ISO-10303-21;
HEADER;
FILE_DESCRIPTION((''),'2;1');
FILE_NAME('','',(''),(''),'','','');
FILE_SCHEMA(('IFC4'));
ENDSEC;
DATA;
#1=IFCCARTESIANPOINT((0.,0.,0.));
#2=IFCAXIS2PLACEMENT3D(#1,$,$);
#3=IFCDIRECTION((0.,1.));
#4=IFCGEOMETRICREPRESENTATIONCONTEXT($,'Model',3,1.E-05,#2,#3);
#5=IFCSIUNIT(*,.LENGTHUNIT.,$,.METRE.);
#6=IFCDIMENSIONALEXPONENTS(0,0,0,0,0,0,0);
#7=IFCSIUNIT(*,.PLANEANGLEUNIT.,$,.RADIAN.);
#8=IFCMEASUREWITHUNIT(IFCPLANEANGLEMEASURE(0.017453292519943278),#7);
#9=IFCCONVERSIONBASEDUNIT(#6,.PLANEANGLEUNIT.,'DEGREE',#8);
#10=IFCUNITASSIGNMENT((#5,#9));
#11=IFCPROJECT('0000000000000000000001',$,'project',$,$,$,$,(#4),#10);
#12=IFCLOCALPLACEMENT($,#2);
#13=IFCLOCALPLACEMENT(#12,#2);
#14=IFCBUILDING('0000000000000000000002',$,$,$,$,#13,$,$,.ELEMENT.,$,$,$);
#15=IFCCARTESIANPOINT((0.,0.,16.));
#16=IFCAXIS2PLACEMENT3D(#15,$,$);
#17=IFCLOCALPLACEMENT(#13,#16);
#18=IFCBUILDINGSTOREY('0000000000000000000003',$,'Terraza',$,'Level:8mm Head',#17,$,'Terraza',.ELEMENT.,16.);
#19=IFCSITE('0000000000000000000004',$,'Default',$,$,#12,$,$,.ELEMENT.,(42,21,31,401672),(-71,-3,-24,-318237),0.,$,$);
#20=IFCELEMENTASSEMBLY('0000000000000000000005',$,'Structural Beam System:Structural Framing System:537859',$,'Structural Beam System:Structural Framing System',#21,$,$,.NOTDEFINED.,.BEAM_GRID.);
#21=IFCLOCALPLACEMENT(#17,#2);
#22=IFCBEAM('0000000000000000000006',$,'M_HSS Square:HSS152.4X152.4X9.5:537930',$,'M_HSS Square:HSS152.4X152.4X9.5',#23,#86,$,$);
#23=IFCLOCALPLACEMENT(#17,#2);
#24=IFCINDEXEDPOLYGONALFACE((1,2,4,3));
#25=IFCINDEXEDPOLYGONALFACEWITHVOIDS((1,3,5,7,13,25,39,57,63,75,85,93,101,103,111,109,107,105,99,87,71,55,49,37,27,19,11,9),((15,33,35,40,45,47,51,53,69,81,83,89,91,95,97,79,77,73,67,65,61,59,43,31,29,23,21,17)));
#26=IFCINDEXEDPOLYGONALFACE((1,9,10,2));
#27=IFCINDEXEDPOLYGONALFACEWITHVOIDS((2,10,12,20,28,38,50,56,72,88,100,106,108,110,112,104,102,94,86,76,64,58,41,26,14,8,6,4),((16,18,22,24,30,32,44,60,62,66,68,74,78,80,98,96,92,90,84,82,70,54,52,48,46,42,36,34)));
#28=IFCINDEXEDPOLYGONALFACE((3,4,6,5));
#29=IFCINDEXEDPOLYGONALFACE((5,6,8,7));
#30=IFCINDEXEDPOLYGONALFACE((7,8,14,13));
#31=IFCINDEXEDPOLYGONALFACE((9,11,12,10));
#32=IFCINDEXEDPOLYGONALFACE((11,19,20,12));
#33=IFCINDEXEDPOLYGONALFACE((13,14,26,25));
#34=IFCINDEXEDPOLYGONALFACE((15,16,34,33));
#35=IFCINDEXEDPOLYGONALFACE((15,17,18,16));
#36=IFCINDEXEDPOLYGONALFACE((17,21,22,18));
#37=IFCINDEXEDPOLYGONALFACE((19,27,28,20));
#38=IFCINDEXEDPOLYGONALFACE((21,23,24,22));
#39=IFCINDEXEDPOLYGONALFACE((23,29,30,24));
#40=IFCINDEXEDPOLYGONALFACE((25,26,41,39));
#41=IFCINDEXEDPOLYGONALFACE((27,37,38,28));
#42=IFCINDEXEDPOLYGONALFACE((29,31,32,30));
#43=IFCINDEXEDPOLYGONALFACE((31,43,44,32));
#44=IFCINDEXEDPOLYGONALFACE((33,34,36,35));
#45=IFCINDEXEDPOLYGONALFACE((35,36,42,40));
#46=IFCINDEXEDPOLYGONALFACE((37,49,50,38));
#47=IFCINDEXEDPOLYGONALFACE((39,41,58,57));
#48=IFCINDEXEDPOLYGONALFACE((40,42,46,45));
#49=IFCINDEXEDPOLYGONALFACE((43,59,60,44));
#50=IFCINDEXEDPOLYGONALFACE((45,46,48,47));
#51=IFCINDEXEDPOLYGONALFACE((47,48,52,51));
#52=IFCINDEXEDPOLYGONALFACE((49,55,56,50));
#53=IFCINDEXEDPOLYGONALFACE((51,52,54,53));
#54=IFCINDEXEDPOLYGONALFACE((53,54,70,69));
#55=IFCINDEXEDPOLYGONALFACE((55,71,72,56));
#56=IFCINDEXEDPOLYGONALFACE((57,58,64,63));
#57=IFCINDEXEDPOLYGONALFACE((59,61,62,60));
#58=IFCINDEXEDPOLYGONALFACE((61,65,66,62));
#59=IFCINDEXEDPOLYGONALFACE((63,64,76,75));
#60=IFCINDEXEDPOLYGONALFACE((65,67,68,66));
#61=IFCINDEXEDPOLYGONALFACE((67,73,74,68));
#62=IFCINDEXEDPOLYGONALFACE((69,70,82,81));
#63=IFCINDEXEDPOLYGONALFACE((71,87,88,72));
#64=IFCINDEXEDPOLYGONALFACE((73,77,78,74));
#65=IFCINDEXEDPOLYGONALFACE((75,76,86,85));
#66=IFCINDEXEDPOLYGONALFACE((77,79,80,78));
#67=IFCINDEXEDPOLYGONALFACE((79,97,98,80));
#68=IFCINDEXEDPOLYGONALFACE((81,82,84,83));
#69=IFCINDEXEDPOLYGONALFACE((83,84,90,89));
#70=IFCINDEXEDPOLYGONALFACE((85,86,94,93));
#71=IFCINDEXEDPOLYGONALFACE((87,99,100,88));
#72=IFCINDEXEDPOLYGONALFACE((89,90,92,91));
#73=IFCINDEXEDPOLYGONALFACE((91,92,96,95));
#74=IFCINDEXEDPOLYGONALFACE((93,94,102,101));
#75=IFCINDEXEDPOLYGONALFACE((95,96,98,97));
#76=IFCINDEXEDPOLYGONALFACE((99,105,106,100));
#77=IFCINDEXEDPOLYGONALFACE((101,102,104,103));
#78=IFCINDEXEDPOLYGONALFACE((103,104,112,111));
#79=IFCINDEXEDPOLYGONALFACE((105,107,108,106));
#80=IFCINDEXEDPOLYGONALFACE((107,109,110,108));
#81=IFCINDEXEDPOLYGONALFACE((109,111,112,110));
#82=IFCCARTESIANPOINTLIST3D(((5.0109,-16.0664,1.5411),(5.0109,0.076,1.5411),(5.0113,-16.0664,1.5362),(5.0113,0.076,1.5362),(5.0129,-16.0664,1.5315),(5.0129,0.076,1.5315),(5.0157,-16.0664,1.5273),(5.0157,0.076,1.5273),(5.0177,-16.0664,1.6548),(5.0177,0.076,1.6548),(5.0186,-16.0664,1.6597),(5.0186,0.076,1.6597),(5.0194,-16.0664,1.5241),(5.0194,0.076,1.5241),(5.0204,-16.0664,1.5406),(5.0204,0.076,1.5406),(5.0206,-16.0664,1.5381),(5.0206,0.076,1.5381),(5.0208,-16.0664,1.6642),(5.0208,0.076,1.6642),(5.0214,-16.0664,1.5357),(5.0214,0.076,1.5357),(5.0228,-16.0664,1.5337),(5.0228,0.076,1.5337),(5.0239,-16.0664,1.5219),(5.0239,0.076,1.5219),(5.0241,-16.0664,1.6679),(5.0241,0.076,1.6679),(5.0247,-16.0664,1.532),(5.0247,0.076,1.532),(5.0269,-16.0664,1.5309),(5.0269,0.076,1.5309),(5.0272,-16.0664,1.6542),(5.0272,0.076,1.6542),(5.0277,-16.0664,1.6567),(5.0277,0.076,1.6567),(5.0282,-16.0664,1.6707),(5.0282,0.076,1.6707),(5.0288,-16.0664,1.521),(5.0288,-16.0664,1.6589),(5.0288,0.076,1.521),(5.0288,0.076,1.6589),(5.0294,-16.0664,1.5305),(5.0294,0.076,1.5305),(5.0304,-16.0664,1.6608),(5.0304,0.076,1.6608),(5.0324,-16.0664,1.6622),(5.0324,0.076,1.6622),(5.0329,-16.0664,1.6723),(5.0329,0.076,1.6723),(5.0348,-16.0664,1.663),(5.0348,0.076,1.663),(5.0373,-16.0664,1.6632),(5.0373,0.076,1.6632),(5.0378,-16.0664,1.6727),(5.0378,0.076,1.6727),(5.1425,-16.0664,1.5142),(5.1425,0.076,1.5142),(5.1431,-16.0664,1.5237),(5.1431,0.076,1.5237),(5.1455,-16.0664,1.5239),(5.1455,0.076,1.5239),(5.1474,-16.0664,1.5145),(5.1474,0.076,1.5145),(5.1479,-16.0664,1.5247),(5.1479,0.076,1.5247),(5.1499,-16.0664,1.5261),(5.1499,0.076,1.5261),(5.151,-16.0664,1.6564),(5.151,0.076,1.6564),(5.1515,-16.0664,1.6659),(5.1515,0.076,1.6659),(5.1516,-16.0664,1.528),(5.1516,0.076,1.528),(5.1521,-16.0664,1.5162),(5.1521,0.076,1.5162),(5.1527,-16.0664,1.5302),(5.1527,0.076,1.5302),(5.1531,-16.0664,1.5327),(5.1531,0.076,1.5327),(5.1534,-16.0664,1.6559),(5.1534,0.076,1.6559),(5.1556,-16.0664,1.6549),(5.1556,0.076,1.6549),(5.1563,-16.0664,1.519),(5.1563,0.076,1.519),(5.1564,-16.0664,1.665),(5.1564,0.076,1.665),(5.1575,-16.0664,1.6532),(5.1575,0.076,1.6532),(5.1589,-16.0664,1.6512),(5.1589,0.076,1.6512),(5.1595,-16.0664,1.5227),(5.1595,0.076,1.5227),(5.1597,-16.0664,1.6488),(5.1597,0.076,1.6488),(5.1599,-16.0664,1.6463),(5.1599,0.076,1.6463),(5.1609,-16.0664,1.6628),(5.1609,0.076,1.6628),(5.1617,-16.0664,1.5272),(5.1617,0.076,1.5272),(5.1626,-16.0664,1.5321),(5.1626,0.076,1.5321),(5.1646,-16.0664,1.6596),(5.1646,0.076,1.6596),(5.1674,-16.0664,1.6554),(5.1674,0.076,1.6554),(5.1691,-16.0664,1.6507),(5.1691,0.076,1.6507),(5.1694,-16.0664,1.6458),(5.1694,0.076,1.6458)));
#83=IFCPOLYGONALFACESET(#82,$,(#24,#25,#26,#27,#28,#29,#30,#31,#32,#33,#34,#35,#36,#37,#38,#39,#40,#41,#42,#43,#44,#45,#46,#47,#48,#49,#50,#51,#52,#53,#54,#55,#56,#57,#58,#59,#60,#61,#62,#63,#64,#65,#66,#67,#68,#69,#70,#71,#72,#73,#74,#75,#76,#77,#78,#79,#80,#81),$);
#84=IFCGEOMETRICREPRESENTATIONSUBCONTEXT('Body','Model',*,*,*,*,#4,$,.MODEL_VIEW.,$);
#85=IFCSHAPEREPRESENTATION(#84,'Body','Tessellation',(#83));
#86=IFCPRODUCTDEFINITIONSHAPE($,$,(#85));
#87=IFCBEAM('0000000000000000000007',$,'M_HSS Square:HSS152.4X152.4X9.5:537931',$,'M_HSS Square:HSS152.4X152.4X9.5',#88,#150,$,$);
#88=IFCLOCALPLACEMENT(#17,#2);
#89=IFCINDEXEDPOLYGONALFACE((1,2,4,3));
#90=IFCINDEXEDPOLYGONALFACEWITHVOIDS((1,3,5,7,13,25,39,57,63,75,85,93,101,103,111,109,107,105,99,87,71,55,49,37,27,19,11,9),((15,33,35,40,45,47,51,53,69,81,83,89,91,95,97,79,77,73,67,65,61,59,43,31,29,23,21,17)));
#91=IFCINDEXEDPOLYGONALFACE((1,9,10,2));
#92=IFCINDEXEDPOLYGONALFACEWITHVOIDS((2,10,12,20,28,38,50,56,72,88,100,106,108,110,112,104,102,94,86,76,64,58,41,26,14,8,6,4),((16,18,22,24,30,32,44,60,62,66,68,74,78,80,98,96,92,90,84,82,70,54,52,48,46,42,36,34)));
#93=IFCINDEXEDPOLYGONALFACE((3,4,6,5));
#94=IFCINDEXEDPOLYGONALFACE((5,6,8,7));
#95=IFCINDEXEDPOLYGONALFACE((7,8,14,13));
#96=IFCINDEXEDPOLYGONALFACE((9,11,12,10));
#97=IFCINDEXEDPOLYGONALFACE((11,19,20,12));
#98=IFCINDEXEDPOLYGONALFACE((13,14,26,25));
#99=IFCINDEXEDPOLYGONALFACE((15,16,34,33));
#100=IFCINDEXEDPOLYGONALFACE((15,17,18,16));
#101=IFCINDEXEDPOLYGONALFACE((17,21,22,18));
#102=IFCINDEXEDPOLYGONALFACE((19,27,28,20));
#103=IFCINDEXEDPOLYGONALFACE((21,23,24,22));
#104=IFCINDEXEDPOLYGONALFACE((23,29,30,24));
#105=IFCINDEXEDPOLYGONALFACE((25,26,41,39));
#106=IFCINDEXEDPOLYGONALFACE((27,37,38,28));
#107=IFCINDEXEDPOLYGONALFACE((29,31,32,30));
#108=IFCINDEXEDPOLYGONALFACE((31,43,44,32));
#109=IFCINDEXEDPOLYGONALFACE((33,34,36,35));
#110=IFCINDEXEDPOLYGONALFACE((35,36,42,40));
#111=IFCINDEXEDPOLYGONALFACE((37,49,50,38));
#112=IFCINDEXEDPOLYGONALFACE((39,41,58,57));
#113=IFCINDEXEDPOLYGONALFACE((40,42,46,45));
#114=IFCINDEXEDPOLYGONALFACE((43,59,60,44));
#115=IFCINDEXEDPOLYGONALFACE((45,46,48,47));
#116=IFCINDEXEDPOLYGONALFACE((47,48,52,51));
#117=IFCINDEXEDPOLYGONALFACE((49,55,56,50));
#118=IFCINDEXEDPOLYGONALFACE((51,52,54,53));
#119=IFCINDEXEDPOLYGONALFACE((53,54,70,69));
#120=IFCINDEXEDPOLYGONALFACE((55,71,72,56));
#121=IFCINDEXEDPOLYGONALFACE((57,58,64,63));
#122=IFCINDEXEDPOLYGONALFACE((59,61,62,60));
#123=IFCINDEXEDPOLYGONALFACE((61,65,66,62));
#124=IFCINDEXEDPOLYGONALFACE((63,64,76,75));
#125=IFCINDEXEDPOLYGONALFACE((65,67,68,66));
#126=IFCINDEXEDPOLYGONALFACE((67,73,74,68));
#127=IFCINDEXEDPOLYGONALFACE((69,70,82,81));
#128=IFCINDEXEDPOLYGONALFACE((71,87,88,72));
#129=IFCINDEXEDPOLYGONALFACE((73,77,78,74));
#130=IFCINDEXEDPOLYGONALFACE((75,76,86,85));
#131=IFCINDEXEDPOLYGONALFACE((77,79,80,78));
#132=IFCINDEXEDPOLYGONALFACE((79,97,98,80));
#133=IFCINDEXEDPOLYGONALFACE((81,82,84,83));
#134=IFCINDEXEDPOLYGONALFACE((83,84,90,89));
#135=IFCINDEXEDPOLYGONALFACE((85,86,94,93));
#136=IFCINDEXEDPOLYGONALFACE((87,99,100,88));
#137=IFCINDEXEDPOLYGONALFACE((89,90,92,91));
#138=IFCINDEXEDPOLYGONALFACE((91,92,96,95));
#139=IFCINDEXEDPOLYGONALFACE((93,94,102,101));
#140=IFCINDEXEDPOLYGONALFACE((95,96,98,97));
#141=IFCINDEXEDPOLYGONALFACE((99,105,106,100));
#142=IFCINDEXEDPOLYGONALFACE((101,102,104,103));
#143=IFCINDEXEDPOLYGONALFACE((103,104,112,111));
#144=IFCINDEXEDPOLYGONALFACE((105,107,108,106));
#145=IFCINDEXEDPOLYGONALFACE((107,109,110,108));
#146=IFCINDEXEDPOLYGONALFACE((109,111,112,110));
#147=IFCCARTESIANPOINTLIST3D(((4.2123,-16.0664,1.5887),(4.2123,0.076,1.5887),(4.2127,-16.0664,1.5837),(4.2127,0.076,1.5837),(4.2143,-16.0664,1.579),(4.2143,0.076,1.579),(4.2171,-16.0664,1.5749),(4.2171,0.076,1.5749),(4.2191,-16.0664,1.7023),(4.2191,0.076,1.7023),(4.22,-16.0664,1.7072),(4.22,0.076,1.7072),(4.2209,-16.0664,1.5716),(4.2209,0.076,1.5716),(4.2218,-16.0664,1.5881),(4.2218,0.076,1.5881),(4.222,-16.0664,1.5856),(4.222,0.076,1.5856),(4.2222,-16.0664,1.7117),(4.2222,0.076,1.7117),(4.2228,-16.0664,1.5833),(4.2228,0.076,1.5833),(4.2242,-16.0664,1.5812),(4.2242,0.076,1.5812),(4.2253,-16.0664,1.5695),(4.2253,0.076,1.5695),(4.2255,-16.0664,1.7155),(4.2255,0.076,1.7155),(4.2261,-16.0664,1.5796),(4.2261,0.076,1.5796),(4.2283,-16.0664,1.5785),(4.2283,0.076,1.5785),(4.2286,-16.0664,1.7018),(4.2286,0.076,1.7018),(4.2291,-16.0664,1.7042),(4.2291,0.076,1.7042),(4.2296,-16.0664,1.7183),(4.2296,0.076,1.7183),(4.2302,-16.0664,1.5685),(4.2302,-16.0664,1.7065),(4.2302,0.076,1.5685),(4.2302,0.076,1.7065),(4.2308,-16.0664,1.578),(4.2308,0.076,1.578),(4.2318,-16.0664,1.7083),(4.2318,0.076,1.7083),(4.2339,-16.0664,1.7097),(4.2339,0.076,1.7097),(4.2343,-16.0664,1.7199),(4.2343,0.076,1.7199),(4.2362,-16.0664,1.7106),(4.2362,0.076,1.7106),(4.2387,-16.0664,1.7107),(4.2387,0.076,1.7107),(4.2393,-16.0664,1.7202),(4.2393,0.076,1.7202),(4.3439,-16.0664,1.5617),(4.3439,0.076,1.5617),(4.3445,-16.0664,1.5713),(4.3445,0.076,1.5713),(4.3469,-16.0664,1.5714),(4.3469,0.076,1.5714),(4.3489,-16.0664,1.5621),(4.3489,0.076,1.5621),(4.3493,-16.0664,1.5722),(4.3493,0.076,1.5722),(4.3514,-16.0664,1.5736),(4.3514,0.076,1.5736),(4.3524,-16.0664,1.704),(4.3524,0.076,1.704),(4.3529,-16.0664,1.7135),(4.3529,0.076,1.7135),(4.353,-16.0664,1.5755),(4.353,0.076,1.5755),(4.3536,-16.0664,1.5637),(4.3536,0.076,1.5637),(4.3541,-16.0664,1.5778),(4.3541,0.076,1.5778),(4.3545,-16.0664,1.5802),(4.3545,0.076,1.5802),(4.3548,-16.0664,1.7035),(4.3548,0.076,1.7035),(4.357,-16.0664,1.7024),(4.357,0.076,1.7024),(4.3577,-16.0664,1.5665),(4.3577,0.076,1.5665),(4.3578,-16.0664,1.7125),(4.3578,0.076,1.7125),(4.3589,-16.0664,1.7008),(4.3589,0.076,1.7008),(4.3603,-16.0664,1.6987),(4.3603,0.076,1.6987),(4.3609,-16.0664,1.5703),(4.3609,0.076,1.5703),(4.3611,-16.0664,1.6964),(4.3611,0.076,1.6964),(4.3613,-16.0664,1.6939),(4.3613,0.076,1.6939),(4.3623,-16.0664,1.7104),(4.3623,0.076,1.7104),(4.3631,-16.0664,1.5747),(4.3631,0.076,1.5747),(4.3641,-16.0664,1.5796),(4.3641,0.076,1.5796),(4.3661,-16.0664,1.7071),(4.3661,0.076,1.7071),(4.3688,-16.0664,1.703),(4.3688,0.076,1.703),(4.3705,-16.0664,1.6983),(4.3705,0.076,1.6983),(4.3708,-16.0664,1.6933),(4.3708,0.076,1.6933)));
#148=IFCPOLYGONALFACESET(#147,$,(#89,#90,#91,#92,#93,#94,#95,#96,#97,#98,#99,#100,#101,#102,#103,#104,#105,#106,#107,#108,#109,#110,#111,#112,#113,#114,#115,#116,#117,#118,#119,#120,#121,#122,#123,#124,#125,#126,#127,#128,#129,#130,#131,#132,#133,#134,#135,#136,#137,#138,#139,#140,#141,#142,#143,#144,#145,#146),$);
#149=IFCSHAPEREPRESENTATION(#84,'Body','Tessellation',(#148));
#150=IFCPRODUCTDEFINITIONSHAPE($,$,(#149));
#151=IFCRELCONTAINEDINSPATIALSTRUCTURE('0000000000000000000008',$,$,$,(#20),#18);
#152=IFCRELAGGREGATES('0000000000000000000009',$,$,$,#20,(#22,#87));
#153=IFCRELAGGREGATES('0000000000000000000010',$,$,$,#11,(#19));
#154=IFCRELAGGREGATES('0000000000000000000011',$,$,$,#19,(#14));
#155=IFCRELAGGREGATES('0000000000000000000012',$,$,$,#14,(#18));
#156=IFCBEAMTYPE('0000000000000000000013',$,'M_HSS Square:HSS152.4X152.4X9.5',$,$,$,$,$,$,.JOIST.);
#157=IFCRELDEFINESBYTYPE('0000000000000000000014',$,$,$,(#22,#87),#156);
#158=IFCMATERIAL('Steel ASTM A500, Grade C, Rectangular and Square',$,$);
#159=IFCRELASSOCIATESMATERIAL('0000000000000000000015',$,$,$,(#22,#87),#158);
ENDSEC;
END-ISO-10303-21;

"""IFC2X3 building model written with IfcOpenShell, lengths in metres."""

from ifc_helpers import new_model, entity, si_unit, converted_unit, direction, frame, frame_2d, origin, place, context, subcontext, project, spatial, polyline, circle_curve, parameter, trimmed, segment, composite_curve, outline, extrude, material, type_object, element, aggregate, save


model = new_model("IFC2X3")

# Units and contexts
model_context = context("Model", 3, precision=1e-05, world=origin(), true_north=direction((0.0, 1.0)))
body_context = subcontext(model_context, "Body", "Model", "MODEL_VIEW")
ifc_project = project(units=[si_unit("LENGTHUNIT", "METRE"), converted_unit("PLANEANGLEUNIT", "DEGREE", entity("IfcPlaneAngleMeasure", 0.017453292519943278), si_unit("PLANEANGLEUNIT", "RADIAN"), dimensions=[0, 0, 0, 0, 0, 0, 0])], contexts=[model_context])

# Site, building, storey
site_placement = place(None, origin())
site = spatial("IfcSite", under=ifc_project, at=site_placement, Name="Default", CompositionType="ELEMENT", RefLatitude=(42, 21, 31, 401672), RefLongitude=(-71, -3, -24, -318237), RefElevation=0.0)
building_placement = place(site_placement, origin())
building = spatial("IfcBuilding", under=site, at=building_placement, CompositionType="ELEMENT")
storey_placement = place(building_placement, frame((0.0, 0.0, 16.0)))
storey = spatial("IfcBuildingStorey", under=building, at=storey_placement, Name="Terraza", ObjectType="Level:8mm Head", LongName="Terraza", CompositionType="ELEMENT", Elevation=16.0)

# Element assembly, beams
assembly_1_placement = place(storey_placement, origin())
assembly_1 = element("IfcElementAssembly", 1, at=assembly_1_placement, inside=storey, Name="Structural Beam System:Structural Framing System:537859", ObjectType="Structural Beam System:Structural Framing System", AssemblyPlace="NOTDEFINED", PredefinedType="BEAM_GRID")
ifc_material_1 = material(Name="Steel ASTM A500, Grade C, Rectangular and Square")
beam_type = type_object("IfcBeamType", Name="M_HSS Square:HSS152.4X152.4X9.5", PredefinedType="JOIST")
beam_1_placement = place(assembly_1_placement, frame((5.0856, 0.076, 1.5176), z_axis=(0.0, 0.0, 1.0), x_axis=(0.0, -1.0, 0.0)))
beam_1 = element("IfcBeam", 2, at=beam_1_placement, type_object=beam_type, material=ifc_material_1, Name="M_HSS Square:HSS152.4X152.4X9.5:537930", ObjectType="M_HSS Square:HSS152.4X152.4X9.5", context=body_context, shape_type="SweptSolid", body=[
    extrude(outline(composite_curve([segment(polyline([(-0.0569, -0.076), (0.0569, -0.076)]), True, "CONTINUOUS"), segment(trimmed(circle_curve(frame_2d((0.0569, -0.0569), x_axis=(0.0, 1.0)), 0.0191), [parameter(180.0)], [parameter(270.0)], True, "PARAMETER"), True, "CONTINUOUS"), segment(polyline([(0.076, -0.0569), (0.076, 0.0569)]), True, "CONTINUOUS"), segment(trimmed(circle_curve(frame_2d((0.0569, 0.0569), x_axis=(0.0, 1.0)), 0.0191), [parameter(270.0)], [parameter(0.0)], True, "PARAMETER"), True, "CONTINUOUS"), segment(polyline([(0.0569, 0.076), (-0.0569, 0.076)]), True, "CONTINUOUS"), segment(trimmed(circle_curve(frame_2d((-0.0569, 0.0569), x_axis=(0.0, 1.0)), 0.0191), [parameter(0.0)], [parameter(90.0)], True, "PARAMETER"), True, "CONTINUOUS"), segment(polyline([(-0.076, 0.0569), (-0.076, -0.0569)]), True, "CONTINUOUS"), segment(trimmed(circle_curve(frame_2d((-0.0569, -0.0569), x_axis=(0.0, 1.0)), 0.0191), [parameter(90.0)], [parameter(180.0)], True, "PARAMETER"), True, "CONTINUOUS")], self_intersect=False), holes=[composite_curve([segment(trimmed(circle_curve(frame_2d((-0.0569, 0.0569), x_axis=(0.0, 1.0)), 0.0095), [parameter(360.0)], [parameter(90.0)], True, "PARAMETER"), False, "CONTINUOUS"), segment(polyline([(-0.0569, 0.0665), (0.0569, 0.0665)]), True, "CONTINUOUS"), segment(trimmed(circle_curve(frame_2d((0.0569, 0.0569), x_axis=(0.0, 1.0)), 0.0095), [parameter(270.0)], [parameter(360.0)], True, "PARAMETER"), False, "CONTINUOUS"), segment(polyline([(0.0665, 0.0569), (0.0665, -0.0569)]), True, "CONTINUOUS"), segment(trimmed(circle_curve(frame_2d((0.0569, -0.0569), x_axis=(0.0, 1.0)), 0.0095), [parameter(180.0)], [parameter(270.0)], True, "PARAMETER"), False, "CONTINUOUS"), segment(polyline([(0.0569, -0.0665), (-0.0569, -0.0665)]), True, "CONTINUOUS"), segment(trimmed(circle_curve(frame_2d((-0.0569, -0.0569), x_axis=(0.0, 1.0)), 0.0095), [parameter(90.0)], [parameter(180.0)], True, "PARAMETER"), False, "CONTINUOUS"), segment(polyline([(-0.0665, -0.0569), (-0.0665, 0.0569)]), True, "CONTINUOUS")], self_intersect=False)]), frame((0.0, 0.0045, 0.0759), z_axis=(1.0, 0.0, 0.0), x_axis=(0.0, -0.059434, -0.998232)), (0.0, 0.0, 1.0), 16.1424),
])
beam_2_placement = place(assembly_1_placement, frame((4.2871, 0.076, 1.5651), z_axis=(0.0, 0.0, 1.0), x_axis=(0.0, -1.0, 0.0)))
beam_2 = element("IfcBeam", 3, at=beam_2_placement, type_object=beam_type, material=ifc_material_1, Name="M_HSS Square:HSS152.4X152.4X9.5:537931", ObjectType="M_HSS Square:HSS152.4X152.4X9.5", context=body_context, shape_type="SweptSolid", body=[
    extrude(outline(composite_curve([segment(polyline([(-0.0569, -0.076), (0.0569, -0.076)]), True, "CONTINUOUS"), segment(trimmed(circle_curve(frame_2d((0.0569, -0.0569), x_axis=(0.0, 1.0)), 0.0191), [parameter(180.0)], [parameter(270.0)], True, "PARAMETER"), True, "CONTINUOUS"), segment(polyline([(0.076, -0.0569), (0.076, 0.0569)]), True, "CONTINUOUS"), segment(trimmed(circle_curve(frame_2d((0.0569, 0.0569), x_axis=(0.0, 1.0)), 0.0191), [parameter(270.0)], [parameter(0.0)], True, "PARAMETER"), True, "CONTINUOUS"), segment(polyline([(0.0569, 0.076), (-0.0569, 0.076)]), True, "CONTINUOUS"), segment(trimmed(circle_curve(frame_2d((-0.0569, 0.0569), x_axis=(0.0, 1.0)), 0.0191), [parameter(0.0)], [parameter(90.0)], True, "PARAMETER"), True, "CONTINUOUS"), segment(polyline([(-0.076, 0.0569), (-0.076, -0.0569)]), True, "CONTINUOUS"), segment(trimmed(circle_curve(frame_2d((-0.0569, -0.0569), x_axis=(0.0, 1.0)), 0.0191), [parameter(90.0)], [parameter(180.0)], True, "PARAMETER"), True, "CONTINUOUS")], self_intersect=False), holes=[composite_curve([segment(trimmed(circle_curve(frame_2d((-0.0569, 0.0569), x_axis=(0.0, 1.0)), 0.0095), [parameter(360.0)], [parameter(90.0)], True, "PARAMETER"), False, "CONTINUOUS"), segment(polyline([(-0.0569, 0.0665), (0.0569, 0.0665)]), True, "CONTINUOUS"), segment(trimmed(circle_curve(frame_2d((0.0569, 0.0569), x_axis=(0.0, 1.0)), 0.0095), [parameter(270.0)], [parameter(360.0)], True, "PARAMETER"), False, "CONTINUOUS"), segment(polyline([(0.0665, 0.0569), (0.0665, -0.0569)]), True, "CONTINUOUS"), segment(trimmed(circle_curve(frame_2d((0.0569, -0.0569), x_axis=(0.0, 1.0)), 0.0095), [parameter(180.0)], [parameter(270.0)], True, "PARAMETER"), False, "CONTINUOUS"), segment(polyline([(0.0569, -0.0665), (-0.0569, -0.0665)]), True, "CONTINUOUS"), segment(trimmed(circle_curve(frame_2d((-0.0569, -0.0569), x_axis=(0.0, 1.0)), 0.0095), [parameter(90.0)], [parameter(180.0)], True, "PARAMETER"), False, "CONTINUOUS"), segment(polyline([(-0.0665, -0.0569), (-0.0665, 0.0569)]), True, "CONTINUOUS")], self_intersect=False)]), frame((0.0, 0.0045, 0.0759), z_axis=(1.0, 0.0, 0.0), x_axis=(0.0, -0.059434, -0.998232)), (0.0, 0.0, 1.0), 16.1424),
])
aggregate(assembly_1, [beam_1, beam_2])

save(model, "model.ifc")
